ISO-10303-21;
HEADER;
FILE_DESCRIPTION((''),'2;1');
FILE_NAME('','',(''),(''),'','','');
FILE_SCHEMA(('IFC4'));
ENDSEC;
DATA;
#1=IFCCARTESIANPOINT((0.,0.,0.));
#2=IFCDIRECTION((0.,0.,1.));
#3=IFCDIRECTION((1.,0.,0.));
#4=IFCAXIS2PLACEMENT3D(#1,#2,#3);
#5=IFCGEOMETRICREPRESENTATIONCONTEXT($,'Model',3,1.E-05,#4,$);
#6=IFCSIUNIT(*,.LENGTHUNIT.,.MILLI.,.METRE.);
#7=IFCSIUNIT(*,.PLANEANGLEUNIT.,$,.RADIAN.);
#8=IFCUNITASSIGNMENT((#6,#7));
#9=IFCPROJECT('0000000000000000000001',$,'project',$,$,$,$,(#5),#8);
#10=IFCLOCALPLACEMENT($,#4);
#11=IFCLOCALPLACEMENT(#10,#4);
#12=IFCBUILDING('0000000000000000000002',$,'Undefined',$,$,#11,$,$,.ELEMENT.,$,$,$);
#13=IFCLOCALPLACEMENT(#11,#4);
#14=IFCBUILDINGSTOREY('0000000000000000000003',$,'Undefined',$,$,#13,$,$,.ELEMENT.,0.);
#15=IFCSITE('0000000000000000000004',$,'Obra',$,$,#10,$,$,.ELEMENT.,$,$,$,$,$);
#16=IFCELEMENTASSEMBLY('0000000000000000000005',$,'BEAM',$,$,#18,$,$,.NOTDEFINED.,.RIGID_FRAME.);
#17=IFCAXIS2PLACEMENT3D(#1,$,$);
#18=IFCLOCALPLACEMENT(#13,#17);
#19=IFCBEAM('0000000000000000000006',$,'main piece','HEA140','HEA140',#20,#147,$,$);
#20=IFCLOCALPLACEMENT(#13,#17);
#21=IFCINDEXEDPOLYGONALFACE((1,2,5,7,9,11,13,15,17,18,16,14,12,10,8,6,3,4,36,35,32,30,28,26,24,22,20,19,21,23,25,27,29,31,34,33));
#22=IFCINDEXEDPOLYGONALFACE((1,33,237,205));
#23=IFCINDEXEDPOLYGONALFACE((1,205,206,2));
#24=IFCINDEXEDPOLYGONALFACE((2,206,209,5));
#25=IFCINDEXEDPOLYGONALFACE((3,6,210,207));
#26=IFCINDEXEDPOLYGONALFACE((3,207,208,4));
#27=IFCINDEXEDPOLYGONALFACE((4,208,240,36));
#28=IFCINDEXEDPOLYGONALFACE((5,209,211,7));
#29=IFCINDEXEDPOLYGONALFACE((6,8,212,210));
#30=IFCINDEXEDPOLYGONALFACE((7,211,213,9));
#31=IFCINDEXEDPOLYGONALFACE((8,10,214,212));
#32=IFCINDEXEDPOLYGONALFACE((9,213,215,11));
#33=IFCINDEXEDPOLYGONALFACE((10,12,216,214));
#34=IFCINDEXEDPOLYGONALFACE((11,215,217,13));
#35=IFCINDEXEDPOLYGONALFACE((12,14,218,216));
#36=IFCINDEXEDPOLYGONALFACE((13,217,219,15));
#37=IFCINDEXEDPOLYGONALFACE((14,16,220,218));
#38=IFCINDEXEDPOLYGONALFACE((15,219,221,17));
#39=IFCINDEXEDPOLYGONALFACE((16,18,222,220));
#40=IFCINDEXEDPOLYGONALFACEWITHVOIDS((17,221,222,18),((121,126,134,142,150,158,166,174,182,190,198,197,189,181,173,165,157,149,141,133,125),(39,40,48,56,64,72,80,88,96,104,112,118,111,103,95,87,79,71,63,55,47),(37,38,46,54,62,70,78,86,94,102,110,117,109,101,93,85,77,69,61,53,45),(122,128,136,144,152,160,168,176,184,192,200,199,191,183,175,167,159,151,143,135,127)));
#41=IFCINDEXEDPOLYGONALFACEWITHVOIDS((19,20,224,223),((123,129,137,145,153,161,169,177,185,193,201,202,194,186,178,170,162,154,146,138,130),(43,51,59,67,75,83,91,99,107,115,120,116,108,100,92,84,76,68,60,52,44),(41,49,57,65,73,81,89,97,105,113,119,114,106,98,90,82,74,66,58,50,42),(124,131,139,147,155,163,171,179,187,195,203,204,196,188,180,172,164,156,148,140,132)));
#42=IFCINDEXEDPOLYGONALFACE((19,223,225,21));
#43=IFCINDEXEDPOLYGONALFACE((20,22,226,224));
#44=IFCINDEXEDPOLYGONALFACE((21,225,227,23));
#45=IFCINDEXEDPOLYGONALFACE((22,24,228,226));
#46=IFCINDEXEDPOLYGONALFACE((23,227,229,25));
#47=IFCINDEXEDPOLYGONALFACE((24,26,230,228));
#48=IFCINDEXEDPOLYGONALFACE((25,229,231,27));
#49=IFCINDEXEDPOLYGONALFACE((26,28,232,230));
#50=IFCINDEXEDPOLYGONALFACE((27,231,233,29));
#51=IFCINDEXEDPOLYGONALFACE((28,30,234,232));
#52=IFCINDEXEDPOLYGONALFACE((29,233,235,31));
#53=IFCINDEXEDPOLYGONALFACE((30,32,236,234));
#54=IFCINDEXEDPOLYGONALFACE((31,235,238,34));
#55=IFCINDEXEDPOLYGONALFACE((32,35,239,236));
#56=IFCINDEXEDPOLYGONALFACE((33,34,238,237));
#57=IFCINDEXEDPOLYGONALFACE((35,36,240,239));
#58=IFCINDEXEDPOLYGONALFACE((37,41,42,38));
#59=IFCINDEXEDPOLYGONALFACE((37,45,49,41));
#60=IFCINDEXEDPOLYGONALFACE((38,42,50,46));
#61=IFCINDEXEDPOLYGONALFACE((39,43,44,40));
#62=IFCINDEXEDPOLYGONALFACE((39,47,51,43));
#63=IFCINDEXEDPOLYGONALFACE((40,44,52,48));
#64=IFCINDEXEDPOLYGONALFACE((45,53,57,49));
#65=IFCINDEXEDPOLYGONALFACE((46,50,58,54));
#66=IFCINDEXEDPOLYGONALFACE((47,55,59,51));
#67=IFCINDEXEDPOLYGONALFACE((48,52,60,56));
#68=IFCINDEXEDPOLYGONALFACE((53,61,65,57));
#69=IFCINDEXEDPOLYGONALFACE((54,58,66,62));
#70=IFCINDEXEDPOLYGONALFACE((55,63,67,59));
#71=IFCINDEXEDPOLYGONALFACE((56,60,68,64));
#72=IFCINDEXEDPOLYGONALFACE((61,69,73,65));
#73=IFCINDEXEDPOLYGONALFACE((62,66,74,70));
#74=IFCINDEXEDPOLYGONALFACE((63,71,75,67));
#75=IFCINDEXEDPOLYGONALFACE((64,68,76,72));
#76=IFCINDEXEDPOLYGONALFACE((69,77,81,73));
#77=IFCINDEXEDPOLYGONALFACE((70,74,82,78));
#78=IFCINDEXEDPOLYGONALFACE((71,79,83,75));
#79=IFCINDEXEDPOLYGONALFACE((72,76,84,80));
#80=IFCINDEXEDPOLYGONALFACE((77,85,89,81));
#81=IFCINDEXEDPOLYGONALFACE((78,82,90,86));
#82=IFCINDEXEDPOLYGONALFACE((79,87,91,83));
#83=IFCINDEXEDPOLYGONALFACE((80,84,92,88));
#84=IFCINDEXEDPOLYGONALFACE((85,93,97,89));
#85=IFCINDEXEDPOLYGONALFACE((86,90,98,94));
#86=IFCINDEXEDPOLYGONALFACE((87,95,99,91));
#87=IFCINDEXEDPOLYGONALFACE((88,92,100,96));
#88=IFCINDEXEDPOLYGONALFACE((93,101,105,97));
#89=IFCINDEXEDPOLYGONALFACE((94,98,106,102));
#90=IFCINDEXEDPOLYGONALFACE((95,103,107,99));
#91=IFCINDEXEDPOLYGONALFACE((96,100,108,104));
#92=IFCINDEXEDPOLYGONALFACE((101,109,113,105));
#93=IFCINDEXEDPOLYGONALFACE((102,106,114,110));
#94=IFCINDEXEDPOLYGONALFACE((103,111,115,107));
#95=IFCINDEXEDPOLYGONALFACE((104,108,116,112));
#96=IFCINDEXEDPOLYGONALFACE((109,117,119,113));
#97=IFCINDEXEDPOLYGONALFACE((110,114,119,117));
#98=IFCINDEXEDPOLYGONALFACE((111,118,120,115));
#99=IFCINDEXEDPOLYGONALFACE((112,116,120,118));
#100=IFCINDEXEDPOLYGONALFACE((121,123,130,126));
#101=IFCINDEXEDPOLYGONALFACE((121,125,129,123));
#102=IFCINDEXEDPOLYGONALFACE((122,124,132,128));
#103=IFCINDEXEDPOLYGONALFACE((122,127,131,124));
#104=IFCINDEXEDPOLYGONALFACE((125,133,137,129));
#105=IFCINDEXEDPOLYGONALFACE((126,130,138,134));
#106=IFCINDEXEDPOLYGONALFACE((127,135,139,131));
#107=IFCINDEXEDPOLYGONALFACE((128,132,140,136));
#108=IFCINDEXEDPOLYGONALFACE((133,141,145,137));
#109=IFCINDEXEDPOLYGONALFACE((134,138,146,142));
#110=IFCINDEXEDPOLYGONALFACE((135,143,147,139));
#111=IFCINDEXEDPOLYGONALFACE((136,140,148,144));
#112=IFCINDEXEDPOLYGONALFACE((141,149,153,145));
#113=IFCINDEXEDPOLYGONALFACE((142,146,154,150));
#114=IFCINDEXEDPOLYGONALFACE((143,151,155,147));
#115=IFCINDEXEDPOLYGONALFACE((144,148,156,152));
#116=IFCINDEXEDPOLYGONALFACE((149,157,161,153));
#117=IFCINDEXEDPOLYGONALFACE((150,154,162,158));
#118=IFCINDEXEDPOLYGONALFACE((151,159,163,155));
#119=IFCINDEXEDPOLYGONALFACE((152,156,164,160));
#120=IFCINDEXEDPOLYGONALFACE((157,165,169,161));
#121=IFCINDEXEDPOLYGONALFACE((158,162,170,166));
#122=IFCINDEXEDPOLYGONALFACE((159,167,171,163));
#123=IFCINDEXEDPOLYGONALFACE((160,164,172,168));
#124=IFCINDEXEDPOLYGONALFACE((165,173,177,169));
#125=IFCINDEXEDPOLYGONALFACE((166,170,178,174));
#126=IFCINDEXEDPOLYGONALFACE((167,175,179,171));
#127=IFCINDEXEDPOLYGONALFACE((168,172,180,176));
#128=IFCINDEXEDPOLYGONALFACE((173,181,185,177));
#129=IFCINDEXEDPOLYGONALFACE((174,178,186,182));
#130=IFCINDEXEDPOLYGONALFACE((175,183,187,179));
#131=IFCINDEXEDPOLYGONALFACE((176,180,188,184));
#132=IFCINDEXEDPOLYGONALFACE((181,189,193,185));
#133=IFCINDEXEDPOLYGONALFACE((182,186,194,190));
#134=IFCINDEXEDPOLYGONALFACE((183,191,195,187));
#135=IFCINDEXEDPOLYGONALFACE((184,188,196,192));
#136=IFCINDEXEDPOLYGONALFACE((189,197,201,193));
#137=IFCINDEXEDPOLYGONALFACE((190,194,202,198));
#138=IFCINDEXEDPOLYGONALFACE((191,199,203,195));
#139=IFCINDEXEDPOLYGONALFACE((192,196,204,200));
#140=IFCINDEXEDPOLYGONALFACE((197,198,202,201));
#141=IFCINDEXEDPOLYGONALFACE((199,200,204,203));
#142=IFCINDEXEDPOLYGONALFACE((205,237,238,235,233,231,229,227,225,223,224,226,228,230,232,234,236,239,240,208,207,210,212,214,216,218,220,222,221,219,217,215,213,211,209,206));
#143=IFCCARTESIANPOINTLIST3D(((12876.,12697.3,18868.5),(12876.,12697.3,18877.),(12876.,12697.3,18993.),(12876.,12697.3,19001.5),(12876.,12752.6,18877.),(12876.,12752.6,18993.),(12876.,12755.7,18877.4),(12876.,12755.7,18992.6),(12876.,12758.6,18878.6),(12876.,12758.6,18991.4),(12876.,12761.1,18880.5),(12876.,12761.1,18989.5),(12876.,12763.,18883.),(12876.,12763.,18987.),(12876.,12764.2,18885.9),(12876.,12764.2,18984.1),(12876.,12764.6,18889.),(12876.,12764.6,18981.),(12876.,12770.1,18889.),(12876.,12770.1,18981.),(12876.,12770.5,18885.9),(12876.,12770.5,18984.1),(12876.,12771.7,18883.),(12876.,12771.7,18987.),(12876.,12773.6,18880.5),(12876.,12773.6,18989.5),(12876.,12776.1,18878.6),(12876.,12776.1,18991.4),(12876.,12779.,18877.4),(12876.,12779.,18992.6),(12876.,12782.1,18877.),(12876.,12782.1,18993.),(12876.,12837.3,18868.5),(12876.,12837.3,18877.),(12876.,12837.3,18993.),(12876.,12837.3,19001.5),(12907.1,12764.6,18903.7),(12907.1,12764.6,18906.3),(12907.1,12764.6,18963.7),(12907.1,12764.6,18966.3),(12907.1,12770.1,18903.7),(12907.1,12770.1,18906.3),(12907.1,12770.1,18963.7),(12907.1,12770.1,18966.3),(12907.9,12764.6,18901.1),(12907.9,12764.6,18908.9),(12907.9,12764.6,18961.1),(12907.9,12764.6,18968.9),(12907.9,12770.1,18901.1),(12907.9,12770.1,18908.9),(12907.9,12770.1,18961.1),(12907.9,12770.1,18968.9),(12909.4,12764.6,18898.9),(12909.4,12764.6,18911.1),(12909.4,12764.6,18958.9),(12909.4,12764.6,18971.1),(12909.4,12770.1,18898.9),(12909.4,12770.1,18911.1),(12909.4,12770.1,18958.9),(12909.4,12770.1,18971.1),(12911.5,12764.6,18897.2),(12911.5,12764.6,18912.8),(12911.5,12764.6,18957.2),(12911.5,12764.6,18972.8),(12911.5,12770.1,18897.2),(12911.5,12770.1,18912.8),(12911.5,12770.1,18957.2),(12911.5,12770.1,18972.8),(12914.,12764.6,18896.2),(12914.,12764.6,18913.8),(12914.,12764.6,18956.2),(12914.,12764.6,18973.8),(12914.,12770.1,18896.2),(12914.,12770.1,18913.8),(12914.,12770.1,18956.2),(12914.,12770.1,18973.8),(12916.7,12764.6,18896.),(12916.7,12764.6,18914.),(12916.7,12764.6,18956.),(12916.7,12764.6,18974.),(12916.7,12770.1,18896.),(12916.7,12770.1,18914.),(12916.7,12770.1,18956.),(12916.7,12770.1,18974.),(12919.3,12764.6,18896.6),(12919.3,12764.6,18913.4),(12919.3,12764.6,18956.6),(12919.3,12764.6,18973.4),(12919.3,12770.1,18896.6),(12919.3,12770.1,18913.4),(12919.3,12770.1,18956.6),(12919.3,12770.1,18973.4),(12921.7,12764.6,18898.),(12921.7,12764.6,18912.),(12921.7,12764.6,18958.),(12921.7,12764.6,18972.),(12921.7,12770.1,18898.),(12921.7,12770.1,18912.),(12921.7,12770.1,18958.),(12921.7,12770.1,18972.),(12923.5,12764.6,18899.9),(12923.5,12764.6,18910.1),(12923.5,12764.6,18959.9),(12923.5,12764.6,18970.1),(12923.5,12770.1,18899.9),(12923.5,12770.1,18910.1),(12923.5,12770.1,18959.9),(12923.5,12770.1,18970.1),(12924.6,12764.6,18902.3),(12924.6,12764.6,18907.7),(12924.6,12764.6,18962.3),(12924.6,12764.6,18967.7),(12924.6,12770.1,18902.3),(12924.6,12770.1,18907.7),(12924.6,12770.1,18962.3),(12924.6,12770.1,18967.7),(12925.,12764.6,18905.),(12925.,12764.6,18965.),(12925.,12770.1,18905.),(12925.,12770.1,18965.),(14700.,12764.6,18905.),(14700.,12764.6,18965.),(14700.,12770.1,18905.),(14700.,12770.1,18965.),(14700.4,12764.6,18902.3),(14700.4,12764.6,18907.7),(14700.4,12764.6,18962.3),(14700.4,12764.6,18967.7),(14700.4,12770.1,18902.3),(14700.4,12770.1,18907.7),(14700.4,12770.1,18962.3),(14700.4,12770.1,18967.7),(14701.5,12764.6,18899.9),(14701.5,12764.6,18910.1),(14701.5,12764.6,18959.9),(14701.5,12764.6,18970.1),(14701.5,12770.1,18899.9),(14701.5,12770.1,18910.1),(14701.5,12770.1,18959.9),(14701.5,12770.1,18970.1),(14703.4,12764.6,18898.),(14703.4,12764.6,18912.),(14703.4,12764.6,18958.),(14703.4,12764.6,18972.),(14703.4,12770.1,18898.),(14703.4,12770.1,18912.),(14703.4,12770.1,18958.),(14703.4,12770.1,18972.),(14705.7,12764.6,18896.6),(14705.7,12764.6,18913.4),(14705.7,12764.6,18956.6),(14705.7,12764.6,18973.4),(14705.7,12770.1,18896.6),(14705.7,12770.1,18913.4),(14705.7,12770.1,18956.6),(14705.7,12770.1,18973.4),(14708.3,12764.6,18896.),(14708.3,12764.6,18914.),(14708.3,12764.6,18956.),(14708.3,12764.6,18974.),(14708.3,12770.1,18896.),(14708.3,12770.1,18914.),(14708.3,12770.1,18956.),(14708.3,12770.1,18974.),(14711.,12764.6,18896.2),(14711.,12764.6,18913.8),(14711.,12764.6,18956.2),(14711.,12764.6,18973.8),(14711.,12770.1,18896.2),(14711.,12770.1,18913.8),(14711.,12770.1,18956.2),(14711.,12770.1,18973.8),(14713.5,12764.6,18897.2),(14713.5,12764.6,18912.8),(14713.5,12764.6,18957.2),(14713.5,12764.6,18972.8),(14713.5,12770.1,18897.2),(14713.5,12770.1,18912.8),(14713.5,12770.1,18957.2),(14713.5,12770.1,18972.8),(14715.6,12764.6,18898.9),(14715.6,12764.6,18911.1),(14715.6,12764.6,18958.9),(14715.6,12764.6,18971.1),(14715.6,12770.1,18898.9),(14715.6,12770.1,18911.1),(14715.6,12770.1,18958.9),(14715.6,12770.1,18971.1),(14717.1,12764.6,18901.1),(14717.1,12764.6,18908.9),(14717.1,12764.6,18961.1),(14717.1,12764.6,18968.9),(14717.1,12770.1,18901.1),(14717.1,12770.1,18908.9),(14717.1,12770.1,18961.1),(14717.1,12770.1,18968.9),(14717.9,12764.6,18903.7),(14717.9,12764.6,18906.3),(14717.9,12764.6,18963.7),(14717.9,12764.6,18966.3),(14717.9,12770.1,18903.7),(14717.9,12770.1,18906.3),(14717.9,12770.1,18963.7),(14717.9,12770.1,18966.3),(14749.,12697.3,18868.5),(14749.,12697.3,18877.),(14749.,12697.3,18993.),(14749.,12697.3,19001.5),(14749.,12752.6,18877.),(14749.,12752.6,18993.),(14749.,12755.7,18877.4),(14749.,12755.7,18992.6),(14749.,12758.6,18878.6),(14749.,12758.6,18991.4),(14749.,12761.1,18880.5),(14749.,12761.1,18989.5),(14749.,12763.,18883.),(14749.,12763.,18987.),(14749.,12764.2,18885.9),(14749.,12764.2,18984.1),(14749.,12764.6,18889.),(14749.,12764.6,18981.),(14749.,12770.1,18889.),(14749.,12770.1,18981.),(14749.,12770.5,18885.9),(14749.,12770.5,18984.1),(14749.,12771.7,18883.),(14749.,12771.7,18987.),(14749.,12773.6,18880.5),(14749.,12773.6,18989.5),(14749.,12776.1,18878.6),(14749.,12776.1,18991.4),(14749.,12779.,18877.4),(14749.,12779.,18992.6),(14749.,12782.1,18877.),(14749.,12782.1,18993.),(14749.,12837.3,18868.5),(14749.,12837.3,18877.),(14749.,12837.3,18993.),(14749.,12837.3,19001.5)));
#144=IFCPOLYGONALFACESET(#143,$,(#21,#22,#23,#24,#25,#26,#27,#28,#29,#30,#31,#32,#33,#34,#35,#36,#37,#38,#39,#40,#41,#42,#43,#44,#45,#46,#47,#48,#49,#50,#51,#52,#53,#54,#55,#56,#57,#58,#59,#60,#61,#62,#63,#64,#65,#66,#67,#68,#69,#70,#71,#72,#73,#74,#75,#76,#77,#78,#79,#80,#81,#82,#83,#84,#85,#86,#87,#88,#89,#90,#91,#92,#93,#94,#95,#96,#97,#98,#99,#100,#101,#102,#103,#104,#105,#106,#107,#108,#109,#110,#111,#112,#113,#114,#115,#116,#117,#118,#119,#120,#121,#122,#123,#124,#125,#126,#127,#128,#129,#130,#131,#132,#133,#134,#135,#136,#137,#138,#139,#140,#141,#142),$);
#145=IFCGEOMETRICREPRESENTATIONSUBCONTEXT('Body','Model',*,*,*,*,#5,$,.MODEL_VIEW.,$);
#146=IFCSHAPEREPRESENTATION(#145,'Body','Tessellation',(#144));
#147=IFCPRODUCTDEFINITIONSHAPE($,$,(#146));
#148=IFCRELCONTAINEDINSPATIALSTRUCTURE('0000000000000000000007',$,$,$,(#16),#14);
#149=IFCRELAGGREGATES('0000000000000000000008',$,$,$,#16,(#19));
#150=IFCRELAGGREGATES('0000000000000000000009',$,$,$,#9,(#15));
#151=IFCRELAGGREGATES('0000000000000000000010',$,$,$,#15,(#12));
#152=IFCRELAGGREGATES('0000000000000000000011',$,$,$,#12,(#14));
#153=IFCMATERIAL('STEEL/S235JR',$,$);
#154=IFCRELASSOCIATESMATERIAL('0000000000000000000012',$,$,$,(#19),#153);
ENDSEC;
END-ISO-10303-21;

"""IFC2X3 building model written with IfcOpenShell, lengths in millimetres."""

from ifc_helpers import new_model, si_unit, frame, origin_with_axes, origin_2d_with_axis, place, context, subcontext, project, spatial, circle, i_section, extrude, clip, halfspace, source, transform, mapped, material, element, aggregate, save


model = new_model("IFC2X3")

# Units and contexts
model_context = context("Model", 3, precision=1e-05, world=origin_with_axes())
body_context = subcontext(model_context, "Body", "Model", "MODEL_VIEW")
ifc_project = project(units=[si_unit("LENGTHUNIT", "METRE", prefix="MILLI"), si_unit("PLANEANGLEUNIT", "RADIAN")], contexts=[model_context])

# Site, building, storey
site_placement = place(None, origin_with_axes())
site = spatial("IfcSite", under=ifc_project, at=site_placement, Name="Obra", CompositionType="ELEMENT")
building_placement = place(site_placement, origin_with_axes())
building = spatial("IfcBuilding", under=site, at=building_placement, Name="Undefined", CompositionType="ELEMENT")
storey_placement = place(building_placement, origin_with_axes())
storey = spatial("IfcBuildingStorey", under=building, at=storey_placement, Name="Undefined", CompositionType="ELEMENT", Elevation=0.0)

# Element assembly, beam, openings
assembly_1_placement = place(storey_placement, origin_with_axes())
assembly_1 = element("IfcElementAssembly", 1, at=assembly_1_placement, inside=storey, Name="BEAM", AssemblyPlace="NOTDEFINED", PredefinedType="RIGID_FRAME")
ifc_material_1 = material(Name="STEEL/S235JR")
beam_1_placement = place(assembly_1_placement, frame((12750.0, 12767.3, 18935.0), z_axis=(0.0, 0.0, 1.0), x_axis=(1.0, 0.0, 0.0)))
beam_1 = element("IfcBeam", 2, at=beam_1_placement, material=ifc_material_1, Name="main piece", Description="HEA140", ObjectType="HEA140", context=body_context, shape_type="Clipping", body=[
    clip(clip(extrude(i_section(OverallWidth=140.0, OverallDepth=133.0, WebThickness=5.5, FlangeThickness=8.5, FilletRadius=12.0, at=origin_2d_with_axis()), frame((2125.0, 0.0, 0.0), z_axis=(-1.0, 0.0, 0.0), x_axis=(0.0, -1.0, 0.0)), (0.0, 0.0, 1.0), 2125.0), halfspace(frame((1999.0, -70.0, -66.5), z_axis=(1.0, 0.0, 0.0), x_axis=(0.0, 0.0, 1.0)), False)), halfspace(frame((126.0, -70.0, -66.5), z_axis=(-1.0, 0.0, 0.0), x_axis=(0.0, 1.0, 0.0)), False)),
])
shared_shape_1 = source(origin_with_axes(), body_context, "Body", "SweptSolid", [
    extrude(circle(Radius=9.0, at=origin_2d_with_axis()), frame((0.0, -0.1, 0.0), z_axis=(0.0, 1.0, 0.0), x_axis=(1.0, 0.0, 0.0)), (0.0, 0.0, 1.0), 5.7),
])
opening_1_placement = place(assembly_1_placement, frame((14709.0, 12770.1, 18935.0), z_axis=(0.0, 0.0, 1.0), x_axis=(-1.0, 0.0, 0.0)))
element("IfcOpeningElement", 3, at=opening_1_placement, cuts=beam_1, ObjectType="Opening", context=body_context, shape_type="MappedRepresentation", body=[
    mapped(shared_shape_1, transform((0.0, 0.0, -30.0))),
    mapped(shared_shape_1, transform((0.0, 0.0, 30.0))),
])
opening_2_placement = place(assembly_1_placement, frame((12916.0, 12770.1, 18935.0), z_axis=(0.0, 0.0, -1.0), x_axis=(1.0, 0.0, 0.0)))
element("IfcOpeningElement", 4, at=opening_2_placement, cuts=beam_1, ObjectType="Opening", context=body_context, shape_type="MappedRepresentation", body=[
    mapped(shared_shape_1, transform((0.0, 0.0, 30.0))),
    mapped(shared_shape_1, transform((0.0, 0.0, -30.0))),
])
aggregate(assembly_1, [beam_1])

save(model, "model.ifc")
